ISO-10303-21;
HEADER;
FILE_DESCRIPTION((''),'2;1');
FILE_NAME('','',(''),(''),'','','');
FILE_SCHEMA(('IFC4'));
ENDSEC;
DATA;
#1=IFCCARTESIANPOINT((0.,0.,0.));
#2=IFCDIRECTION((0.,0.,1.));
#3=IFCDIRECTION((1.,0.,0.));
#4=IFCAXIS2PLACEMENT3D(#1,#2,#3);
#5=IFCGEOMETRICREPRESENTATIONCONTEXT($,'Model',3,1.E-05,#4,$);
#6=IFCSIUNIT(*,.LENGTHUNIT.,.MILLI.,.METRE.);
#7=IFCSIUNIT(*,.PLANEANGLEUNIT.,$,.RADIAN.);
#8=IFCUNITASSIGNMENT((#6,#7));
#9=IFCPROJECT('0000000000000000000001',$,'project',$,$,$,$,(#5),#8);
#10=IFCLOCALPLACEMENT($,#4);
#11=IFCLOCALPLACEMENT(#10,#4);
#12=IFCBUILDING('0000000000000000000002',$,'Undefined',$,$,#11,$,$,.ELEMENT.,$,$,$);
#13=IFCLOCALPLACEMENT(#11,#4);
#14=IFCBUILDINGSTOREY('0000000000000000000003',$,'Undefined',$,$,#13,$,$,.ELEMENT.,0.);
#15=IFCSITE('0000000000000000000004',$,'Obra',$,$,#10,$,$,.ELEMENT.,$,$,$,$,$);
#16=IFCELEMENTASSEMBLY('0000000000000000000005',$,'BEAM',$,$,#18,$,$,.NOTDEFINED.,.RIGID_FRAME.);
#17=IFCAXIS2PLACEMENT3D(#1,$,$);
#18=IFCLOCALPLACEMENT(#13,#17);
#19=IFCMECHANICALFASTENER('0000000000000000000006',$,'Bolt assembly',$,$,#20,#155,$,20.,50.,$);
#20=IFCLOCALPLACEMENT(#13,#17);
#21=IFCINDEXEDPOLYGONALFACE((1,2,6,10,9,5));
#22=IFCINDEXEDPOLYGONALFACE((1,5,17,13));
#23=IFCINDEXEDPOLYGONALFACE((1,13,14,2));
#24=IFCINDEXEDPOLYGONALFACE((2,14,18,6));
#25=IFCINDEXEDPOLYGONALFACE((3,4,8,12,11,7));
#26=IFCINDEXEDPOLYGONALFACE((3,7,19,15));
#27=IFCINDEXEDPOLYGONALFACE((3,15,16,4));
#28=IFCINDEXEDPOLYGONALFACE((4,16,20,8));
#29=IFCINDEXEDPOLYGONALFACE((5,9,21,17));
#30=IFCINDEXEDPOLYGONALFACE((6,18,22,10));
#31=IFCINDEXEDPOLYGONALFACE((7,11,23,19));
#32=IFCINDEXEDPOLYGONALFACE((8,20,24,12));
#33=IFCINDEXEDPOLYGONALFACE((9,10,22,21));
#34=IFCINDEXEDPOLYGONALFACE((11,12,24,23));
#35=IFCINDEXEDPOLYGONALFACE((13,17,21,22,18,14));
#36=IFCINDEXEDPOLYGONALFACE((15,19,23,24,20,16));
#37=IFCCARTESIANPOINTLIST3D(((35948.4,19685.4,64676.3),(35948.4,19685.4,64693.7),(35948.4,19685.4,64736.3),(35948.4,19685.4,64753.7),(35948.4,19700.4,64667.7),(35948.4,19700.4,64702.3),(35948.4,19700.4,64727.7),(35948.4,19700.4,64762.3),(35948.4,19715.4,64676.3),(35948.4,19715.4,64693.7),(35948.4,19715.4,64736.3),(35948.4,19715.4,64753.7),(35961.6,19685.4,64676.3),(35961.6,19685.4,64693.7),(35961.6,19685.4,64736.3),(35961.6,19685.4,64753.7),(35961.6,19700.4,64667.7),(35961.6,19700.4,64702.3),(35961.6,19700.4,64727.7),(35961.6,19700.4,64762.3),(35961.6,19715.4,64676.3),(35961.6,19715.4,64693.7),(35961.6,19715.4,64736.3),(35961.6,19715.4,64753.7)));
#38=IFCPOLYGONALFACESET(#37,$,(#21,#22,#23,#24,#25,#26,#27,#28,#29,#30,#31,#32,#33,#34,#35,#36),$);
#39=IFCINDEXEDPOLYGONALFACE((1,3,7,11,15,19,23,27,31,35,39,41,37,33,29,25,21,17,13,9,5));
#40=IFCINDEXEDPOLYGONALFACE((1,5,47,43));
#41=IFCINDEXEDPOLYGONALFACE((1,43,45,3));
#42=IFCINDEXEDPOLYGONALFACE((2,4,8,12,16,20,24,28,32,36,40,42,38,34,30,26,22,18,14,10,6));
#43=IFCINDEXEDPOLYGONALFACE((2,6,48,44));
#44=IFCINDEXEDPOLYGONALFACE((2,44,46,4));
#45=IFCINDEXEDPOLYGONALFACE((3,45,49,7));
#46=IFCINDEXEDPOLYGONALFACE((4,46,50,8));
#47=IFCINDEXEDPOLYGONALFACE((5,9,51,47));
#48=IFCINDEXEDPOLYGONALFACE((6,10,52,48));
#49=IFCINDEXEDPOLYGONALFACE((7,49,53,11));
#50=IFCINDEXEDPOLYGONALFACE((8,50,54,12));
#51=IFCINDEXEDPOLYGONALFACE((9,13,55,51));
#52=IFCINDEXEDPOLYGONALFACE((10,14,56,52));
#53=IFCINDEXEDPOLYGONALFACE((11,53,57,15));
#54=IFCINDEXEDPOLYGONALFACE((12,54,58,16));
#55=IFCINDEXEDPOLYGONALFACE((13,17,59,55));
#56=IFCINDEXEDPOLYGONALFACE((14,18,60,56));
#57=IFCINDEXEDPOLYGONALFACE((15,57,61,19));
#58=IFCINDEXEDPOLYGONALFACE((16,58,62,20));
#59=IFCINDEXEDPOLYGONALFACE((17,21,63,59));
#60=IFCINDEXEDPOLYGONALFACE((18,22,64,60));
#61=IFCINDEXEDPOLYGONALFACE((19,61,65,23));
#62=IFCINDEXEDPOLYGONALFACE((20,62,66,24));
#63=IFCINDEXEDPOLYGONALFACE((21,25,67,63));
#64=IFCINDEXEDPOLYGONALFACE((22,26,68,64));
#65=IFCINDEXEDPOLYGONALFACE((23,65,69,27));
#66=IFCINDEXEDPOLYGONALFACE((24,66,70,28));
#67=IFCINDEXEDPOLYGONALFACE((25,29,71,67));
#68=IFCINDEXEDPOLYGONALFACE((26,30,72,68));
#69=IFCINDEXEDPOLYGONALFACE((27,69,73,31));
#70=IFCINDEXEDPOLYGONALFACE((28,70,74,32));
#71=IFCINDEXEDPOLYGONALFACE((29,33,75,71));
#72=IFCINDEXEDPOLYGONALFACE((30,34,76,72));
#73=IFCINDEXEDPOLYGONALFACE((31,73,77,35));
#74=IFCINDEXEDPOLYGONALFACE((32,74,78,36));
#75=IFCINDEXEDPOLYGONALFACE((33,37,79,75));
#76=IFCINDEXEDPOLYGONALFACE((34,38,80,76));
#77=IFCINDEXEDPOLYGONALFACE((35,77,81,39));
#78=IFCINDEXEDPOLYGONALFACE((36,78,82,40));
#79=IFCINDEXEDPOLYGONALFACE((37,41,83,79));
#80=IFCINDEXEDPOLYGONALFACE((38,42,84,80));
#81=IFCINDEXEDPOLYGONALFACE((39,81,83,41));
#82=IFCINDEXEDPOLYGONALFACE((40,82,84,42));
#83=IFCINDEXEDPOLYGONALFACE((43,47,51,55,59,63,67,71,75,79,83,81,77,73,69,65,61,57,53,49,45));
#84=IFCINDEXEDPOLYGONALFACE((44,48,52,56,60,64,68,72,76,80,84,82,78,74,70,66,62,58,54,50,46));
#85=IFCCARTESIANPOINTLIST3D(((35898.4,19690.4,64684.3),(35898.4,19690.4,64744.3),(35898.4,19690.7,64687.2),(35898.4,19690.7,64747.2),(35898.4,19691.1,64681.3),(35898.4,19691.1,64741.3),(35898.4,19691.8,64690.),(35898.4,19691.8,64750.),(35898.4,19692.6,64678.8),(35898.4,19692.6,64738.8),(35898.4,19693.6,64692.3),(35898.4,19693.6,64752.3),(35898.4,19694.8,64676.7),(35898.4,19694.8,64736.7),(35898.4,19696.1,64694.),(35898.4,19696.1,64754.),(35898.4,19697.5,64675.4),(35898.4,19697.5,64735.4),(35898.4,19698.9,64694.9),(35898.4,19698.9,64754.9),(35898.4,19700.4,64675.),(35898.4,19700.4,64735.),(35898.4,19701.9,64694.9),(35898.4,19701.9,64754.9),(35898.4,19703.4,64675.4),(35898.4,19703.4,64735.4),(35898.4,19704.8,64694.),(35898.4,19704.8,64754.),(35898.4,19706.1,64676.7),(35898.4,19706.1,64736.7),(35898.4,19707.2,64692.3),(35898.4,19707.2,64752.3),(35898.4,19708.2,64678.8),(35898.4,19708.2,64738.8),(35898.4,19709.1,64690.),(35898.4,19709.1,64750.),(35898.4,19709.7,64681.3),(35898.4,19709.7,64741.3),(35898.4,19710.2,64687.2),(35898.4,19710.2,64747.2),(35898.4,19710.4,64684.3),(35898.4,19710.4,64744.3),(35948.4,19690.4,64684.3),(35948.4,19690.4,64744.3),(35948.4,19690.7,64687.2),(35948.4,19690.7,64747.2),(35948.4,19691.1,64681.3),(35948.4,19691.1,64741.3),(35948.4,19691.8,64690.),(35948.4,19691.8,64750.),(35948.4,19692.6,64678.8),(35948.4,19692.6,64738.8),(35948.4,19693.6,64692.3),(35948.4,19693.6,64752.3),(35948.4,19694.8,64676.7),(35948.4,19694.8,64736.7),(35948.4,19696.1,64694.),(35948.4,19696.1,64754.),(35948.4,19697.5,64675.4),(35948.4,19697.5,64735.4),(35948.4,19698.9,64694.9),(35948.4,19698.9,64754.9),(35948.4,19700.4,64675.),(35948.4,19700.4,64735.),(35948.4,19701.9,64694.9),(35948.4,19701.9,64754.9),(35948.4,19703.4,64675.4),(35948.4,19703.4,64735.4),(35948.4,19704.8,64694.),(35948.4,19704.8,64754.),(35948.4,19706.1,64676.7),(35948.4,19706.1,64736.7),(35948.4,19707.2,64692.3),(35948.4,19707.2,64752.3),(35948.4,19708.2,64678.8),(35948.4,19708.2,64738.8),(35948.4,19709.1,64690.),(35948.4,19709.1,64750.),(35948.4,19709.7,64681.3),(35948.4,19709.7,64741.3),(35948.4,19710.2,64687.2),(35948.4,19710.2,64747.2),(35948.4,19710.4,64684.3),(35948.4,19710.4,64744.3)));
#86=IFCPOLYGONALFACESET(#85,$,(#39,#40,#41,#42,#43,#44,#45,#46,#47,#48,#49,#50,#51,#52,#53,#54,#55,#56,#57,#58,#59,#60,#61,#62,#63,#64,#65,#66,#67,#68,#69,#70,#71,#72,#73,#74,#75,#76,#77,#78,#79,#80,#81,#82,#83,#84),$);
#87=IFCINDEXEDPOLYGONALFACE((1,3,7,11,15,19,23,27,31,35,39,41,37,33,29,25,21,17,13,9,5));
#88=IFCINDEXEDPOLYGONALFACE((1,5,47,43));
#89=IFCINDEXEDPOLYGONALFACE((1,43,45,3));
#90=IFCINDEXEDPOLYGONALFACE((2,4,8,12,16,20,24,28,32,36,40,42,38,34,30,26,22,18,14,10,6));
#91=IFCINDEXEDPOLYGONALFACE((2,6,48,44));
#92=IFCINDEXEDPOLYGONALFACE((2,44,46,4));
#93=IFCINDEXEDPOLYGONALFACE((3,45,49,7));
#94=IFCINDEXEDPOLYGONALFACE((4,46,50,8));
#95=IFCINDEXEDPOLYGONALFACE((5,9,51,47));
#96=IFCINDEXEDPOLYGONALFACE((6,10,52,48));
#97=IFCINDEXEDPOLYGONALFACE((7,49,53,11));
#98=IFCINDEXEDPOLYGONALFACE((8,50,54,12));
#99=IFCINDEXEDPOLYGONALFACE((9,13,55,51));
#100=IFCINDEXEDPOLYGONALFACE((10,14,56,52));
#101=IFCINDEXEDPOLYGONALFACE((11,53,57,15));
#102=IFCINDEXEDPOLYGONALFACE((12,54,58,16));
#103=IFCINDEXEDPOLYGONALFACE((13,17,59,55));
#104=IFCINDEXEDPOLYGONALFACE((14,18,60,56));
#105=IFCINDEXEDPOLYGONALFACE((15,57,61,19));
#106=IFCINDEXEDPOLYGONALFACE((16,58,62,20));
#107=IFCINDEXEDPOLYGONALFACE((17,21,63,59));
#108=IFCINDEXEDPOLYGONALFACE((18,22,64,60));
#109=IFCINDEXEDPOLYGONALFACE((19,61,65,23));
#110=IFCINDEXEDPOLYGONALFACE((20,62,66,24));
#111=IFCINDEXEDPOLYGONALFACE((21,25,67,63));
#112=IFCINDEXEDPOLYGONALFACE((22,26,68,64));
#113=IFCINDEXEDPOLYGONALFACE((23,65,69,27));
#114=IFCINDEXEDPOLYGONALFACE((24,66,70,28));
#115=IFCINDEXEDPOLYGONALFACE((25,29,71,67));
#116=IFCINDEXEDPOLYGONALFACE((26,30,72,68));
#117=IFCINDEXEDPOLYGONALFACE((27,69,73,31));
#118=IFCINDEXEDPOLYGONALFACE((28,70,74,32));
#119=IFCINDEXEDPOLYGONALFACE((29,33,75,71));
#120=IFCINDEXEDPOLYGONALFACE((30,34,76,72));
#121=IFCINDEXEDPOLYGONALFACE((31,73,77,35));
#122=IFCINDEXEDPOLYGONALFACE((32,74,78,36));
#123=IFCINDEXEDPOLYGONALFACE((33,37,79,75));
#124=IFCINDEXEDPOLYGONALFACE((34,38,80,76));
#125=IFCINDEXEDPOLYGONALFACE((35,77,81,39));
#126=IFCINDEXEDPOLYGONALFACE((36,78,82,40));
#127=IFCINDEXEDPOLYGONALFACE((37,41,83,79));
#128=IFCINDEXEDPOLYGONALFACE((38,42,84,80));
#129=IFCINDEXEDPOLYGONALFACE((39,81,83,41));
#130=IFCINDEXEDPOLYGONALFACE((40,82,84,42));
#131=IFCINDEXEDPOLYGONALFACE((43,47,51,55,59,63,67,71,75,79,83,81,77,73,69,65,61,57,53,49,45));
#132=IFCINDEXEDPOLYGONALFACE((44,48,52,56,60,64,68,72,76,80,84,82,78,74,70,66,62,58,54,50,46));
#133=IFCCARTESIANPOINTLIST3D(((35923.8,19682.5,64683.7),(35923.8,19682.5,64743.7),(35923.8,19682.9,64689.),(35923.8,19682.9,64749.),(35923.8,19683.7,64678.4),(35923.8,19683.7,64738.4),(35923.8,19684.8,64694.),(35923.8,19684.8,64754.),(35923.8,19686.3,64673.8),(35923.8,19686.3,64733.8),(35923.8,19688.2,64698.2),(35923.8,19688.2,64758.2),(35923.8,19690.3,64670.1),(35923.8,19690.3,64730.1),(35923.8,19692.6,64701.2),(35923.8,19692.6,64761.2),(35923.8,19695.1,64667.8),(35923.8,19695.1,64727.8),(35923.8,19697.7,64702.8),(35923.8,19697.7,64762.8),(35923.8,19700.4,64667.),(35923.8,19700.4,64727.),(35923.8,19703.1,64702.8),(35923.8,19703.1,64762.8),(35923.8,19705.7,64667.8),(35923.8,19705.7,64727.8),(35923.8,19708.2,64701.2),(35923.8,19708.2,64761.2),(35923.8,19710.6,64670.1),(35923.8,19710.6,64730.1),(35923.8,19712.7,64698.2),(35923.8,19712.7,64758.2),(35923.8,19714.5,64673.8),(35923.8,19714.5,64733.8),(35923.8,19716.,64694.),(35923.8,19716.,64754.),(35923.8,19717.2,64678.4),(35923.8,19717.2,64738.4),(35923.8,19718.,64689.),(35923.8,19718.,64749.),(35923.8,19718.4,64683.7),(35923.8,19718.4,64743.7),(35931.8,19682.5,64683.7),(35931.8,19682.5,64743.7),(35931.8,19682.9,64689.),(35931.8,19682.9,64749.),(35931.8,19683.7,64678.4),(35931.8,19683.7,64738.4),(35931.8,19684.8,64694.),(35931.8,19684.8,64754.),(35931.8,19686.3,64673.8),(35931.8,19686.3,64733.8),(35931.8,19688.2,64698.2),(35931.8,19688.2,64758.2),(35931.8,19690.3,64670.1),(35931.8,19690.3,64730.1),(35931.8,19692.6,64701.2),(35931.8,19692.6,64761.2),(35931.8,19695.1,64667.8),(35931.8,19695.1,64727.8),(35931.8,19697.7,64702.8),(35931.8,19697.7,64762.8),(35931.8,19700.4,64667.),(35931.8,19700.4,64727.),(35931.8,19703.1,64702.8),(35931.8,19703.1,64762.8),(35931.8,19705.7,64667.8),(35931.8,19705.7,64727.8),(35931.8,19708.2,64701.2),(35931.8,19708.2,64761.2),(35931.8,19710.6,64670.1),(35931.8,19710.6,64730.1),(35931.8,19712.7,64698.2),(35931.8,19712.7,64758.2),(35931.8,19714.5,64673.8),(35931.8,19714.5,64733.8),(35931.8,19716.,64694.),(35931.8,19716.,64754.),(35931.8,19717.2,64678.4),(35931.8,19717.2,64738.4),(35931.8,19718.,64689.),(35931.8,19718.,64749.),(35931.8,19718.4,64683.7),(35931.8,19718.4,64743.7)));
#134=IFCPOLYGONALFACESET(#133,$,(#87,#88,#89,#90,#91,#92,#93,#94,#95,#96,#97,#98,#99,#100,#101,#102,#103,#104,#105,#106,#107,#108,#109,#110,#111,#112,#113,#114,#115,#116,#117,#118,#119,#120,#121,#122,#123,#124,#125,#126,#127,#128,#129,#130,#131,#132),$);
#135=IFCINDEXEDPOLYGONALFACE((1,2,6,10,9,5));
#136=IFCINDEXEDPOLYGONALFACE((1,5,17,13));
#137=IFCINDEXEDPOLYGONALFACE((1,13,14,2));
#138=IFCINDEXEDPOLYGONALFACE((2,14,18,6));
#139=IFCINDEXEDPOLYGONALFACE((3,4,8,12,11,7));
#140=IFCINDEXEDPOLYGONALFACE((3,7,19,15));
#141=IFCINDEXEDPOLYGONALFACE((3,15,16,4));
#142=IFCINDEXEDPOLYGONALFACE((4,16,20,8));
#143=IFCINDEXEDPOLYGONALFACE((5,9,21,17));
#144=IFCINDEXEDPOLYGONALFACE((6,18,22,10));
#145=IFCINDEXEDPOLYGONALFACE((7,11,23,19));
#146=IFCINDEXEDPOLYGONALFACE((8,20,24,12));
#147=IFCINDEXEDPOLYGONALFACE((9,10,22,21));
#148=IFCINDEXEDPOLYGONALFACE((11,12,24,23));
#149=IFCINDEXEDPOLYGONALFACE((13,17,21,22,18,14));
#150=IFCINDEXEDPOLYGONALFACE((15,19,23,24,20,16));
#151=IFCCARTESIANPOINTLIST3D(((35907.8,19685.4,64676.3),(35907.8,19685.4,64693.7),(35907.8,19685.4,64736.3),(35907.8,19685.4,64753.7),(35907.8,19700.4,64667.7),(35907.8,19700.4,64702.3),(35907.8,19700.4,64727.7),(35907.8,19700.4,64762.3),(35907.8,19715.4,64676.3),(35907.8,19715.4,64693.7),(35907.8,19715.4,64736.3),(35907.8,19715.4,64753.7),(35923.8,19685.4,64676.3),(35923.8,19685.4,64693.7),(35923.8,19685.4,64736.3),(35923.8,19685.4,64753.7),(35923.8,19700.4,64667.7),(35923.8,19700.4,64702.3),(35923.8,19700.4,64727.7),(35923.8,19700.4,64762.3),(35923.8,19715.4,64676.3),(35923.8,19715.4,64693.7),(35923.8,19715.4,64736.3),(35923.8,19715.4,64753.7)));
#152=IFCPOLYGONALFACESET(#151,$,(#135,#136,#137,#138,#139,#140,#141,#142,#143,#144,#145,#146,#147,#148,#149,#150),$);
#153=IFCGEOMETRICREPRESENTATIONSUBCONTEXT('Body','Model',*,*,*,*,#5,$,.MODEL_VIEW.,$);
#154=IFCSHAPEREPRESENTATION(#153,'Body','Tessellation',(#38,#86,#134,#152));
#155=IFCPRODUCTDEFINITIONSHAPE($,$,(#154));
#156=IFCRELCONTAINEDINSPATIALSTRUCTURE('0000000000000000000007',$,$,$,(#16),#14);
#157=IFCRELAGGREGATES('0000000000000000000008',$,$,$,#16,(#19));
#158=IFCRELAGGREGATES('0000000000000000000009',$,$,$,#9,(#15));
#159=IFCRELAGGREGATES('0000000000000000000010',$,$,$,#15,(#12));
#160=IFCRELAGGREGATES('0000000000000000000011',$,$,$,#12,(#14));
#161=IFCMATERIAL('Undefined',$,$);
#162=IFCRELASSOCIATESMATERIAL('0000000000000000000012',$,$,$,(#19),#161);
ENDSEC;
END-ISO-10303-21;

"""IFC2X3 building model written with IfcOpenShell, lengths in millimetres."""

from ifc_helpers import new_model, si_unit, frame, origin_with_axes, origin_2d_with_axis, place, context, subcontext, project, spatial, polyline, circle, outline, extrude, source, transform, mapped, material, element, aggregate, save


model = new_model("IFC2X3")

# Units and contexts
model_context = context("Model", 3, precision=1e-05, world=origin_with_axes())
body_context = subcontext(model_context, "Body", "Model", "MODEL_VIEW")
ifc_project = project(units=[si_unit("LENGTHUNIT", "METRE", prefix="MILLI"), si_unit("PLANEANGLEUNIT", "RADIAN")], contexts=[model_context])

# Site, building, storey
site_placement = place(None, origin_with_axes())
site = spatial("IfcSite", under=ifc_project, at=site_placement, Name="Obra", CompositionType="ELEMENT")
building_placement = place(site_placement, origin_with_axes())
building = spatial("IfcBuilding", under=site, at=building_placement, Name="Undefined", CompositionType="ELEMENT")
storey_placement = place(building_placement, origin_with_axes())
storey = spatial("IfcBuildingStorey", under=building, at=storey_placement, Name="Undefined", CompositionType="ELEMENT", Elevation=0.0)

# Element assembly, mechanical fastener
assembly_1_placement = place(storey_placement, origin_with_axes())
assembly_1 = element("IfcElementAssembly", 1, at=assembly_1_placement, inside=storey, Name="BEAM", AssemblyPlace="NOTDEFINED", PredefinedType="RIGID_FRAME")
ifc_material = material(Name="Undefined")
shared_shape_1 = source(origin_with_axes(), body_context, "Body", "SweptSolid", [
    extrude(outline(polyline([(17.3, 0.0), (8.7, 15.0), (-8.7, 15.0), (-17.3, 0.0), (-8.7, -15.0), (8.7, -15.0), (17.3, 0.0)])), frame((0.0, -26.5, 0.0), z_axis=(0.0, 1.0, 0.0), x_axis=(1.0, 0.0, 0.0)), (0.0, 0.0, 1.0), 13.2),
    extrude(circle(Radius=10.0, at=origin_2d_with_axis()), frame((0.0, -13.3, 0.0), z_axis=(0.0, 1.0, 0.0), x_axis=(1.0, 0.0, 0.0)), (0.0, 0.0, 1.0), 50.0),
    extrude(circle(Radius=18.0, at=origin_2d_with_axis()), frame((0.0, 3.3, 0.0), z_axis=(0.0, 1.0, 0.0), x_axis=(1.0, 0.0, 0.0)), (0.0, 0.0, 1.0), 8.0),
    extrude(outline(polyline([(17.3, 0.0), (8.7, 15.0), (-8.7, 15.0), (-17.3, 0.0), (-8.7, -15.0), (8.7, -15.0), (17.3, 0.0)])), frame((0.0, 11.3, 0.0), z_axis=(0.0, 1.0, 0.0), x_axis=(1.0, 0.0, 0.0)), (0.0, 0.0, 1.0), 16.0),
])
mechanical_fastener_1_placement = place(assembly_1_placement, frame((35935.1, 19660.4, 64850.0), z_axis=(0.0, 1.0, 0.0), x_axis=(0.0, 0.0, -1.0)))
mechanical_fastener_1 = element("IfcMechanicalFastener", 2, at=mechanical_fastener_1_placement, material=ifc_material, Name="Bolt assembly", NominalDiameter=20.0, NominalLength=50.0, context=body_context, shape_type="MappedRepresentation", body=[
    mapped(shared_shape_1, transform((105.0, 0.0, 40.0))),
    mapped(shared_shape_1, transform((165.0, 0.0, 40.0))),
])
aggregate(assembly_1, [mechanical_fastener_1])

save(model, "model.ifc")
